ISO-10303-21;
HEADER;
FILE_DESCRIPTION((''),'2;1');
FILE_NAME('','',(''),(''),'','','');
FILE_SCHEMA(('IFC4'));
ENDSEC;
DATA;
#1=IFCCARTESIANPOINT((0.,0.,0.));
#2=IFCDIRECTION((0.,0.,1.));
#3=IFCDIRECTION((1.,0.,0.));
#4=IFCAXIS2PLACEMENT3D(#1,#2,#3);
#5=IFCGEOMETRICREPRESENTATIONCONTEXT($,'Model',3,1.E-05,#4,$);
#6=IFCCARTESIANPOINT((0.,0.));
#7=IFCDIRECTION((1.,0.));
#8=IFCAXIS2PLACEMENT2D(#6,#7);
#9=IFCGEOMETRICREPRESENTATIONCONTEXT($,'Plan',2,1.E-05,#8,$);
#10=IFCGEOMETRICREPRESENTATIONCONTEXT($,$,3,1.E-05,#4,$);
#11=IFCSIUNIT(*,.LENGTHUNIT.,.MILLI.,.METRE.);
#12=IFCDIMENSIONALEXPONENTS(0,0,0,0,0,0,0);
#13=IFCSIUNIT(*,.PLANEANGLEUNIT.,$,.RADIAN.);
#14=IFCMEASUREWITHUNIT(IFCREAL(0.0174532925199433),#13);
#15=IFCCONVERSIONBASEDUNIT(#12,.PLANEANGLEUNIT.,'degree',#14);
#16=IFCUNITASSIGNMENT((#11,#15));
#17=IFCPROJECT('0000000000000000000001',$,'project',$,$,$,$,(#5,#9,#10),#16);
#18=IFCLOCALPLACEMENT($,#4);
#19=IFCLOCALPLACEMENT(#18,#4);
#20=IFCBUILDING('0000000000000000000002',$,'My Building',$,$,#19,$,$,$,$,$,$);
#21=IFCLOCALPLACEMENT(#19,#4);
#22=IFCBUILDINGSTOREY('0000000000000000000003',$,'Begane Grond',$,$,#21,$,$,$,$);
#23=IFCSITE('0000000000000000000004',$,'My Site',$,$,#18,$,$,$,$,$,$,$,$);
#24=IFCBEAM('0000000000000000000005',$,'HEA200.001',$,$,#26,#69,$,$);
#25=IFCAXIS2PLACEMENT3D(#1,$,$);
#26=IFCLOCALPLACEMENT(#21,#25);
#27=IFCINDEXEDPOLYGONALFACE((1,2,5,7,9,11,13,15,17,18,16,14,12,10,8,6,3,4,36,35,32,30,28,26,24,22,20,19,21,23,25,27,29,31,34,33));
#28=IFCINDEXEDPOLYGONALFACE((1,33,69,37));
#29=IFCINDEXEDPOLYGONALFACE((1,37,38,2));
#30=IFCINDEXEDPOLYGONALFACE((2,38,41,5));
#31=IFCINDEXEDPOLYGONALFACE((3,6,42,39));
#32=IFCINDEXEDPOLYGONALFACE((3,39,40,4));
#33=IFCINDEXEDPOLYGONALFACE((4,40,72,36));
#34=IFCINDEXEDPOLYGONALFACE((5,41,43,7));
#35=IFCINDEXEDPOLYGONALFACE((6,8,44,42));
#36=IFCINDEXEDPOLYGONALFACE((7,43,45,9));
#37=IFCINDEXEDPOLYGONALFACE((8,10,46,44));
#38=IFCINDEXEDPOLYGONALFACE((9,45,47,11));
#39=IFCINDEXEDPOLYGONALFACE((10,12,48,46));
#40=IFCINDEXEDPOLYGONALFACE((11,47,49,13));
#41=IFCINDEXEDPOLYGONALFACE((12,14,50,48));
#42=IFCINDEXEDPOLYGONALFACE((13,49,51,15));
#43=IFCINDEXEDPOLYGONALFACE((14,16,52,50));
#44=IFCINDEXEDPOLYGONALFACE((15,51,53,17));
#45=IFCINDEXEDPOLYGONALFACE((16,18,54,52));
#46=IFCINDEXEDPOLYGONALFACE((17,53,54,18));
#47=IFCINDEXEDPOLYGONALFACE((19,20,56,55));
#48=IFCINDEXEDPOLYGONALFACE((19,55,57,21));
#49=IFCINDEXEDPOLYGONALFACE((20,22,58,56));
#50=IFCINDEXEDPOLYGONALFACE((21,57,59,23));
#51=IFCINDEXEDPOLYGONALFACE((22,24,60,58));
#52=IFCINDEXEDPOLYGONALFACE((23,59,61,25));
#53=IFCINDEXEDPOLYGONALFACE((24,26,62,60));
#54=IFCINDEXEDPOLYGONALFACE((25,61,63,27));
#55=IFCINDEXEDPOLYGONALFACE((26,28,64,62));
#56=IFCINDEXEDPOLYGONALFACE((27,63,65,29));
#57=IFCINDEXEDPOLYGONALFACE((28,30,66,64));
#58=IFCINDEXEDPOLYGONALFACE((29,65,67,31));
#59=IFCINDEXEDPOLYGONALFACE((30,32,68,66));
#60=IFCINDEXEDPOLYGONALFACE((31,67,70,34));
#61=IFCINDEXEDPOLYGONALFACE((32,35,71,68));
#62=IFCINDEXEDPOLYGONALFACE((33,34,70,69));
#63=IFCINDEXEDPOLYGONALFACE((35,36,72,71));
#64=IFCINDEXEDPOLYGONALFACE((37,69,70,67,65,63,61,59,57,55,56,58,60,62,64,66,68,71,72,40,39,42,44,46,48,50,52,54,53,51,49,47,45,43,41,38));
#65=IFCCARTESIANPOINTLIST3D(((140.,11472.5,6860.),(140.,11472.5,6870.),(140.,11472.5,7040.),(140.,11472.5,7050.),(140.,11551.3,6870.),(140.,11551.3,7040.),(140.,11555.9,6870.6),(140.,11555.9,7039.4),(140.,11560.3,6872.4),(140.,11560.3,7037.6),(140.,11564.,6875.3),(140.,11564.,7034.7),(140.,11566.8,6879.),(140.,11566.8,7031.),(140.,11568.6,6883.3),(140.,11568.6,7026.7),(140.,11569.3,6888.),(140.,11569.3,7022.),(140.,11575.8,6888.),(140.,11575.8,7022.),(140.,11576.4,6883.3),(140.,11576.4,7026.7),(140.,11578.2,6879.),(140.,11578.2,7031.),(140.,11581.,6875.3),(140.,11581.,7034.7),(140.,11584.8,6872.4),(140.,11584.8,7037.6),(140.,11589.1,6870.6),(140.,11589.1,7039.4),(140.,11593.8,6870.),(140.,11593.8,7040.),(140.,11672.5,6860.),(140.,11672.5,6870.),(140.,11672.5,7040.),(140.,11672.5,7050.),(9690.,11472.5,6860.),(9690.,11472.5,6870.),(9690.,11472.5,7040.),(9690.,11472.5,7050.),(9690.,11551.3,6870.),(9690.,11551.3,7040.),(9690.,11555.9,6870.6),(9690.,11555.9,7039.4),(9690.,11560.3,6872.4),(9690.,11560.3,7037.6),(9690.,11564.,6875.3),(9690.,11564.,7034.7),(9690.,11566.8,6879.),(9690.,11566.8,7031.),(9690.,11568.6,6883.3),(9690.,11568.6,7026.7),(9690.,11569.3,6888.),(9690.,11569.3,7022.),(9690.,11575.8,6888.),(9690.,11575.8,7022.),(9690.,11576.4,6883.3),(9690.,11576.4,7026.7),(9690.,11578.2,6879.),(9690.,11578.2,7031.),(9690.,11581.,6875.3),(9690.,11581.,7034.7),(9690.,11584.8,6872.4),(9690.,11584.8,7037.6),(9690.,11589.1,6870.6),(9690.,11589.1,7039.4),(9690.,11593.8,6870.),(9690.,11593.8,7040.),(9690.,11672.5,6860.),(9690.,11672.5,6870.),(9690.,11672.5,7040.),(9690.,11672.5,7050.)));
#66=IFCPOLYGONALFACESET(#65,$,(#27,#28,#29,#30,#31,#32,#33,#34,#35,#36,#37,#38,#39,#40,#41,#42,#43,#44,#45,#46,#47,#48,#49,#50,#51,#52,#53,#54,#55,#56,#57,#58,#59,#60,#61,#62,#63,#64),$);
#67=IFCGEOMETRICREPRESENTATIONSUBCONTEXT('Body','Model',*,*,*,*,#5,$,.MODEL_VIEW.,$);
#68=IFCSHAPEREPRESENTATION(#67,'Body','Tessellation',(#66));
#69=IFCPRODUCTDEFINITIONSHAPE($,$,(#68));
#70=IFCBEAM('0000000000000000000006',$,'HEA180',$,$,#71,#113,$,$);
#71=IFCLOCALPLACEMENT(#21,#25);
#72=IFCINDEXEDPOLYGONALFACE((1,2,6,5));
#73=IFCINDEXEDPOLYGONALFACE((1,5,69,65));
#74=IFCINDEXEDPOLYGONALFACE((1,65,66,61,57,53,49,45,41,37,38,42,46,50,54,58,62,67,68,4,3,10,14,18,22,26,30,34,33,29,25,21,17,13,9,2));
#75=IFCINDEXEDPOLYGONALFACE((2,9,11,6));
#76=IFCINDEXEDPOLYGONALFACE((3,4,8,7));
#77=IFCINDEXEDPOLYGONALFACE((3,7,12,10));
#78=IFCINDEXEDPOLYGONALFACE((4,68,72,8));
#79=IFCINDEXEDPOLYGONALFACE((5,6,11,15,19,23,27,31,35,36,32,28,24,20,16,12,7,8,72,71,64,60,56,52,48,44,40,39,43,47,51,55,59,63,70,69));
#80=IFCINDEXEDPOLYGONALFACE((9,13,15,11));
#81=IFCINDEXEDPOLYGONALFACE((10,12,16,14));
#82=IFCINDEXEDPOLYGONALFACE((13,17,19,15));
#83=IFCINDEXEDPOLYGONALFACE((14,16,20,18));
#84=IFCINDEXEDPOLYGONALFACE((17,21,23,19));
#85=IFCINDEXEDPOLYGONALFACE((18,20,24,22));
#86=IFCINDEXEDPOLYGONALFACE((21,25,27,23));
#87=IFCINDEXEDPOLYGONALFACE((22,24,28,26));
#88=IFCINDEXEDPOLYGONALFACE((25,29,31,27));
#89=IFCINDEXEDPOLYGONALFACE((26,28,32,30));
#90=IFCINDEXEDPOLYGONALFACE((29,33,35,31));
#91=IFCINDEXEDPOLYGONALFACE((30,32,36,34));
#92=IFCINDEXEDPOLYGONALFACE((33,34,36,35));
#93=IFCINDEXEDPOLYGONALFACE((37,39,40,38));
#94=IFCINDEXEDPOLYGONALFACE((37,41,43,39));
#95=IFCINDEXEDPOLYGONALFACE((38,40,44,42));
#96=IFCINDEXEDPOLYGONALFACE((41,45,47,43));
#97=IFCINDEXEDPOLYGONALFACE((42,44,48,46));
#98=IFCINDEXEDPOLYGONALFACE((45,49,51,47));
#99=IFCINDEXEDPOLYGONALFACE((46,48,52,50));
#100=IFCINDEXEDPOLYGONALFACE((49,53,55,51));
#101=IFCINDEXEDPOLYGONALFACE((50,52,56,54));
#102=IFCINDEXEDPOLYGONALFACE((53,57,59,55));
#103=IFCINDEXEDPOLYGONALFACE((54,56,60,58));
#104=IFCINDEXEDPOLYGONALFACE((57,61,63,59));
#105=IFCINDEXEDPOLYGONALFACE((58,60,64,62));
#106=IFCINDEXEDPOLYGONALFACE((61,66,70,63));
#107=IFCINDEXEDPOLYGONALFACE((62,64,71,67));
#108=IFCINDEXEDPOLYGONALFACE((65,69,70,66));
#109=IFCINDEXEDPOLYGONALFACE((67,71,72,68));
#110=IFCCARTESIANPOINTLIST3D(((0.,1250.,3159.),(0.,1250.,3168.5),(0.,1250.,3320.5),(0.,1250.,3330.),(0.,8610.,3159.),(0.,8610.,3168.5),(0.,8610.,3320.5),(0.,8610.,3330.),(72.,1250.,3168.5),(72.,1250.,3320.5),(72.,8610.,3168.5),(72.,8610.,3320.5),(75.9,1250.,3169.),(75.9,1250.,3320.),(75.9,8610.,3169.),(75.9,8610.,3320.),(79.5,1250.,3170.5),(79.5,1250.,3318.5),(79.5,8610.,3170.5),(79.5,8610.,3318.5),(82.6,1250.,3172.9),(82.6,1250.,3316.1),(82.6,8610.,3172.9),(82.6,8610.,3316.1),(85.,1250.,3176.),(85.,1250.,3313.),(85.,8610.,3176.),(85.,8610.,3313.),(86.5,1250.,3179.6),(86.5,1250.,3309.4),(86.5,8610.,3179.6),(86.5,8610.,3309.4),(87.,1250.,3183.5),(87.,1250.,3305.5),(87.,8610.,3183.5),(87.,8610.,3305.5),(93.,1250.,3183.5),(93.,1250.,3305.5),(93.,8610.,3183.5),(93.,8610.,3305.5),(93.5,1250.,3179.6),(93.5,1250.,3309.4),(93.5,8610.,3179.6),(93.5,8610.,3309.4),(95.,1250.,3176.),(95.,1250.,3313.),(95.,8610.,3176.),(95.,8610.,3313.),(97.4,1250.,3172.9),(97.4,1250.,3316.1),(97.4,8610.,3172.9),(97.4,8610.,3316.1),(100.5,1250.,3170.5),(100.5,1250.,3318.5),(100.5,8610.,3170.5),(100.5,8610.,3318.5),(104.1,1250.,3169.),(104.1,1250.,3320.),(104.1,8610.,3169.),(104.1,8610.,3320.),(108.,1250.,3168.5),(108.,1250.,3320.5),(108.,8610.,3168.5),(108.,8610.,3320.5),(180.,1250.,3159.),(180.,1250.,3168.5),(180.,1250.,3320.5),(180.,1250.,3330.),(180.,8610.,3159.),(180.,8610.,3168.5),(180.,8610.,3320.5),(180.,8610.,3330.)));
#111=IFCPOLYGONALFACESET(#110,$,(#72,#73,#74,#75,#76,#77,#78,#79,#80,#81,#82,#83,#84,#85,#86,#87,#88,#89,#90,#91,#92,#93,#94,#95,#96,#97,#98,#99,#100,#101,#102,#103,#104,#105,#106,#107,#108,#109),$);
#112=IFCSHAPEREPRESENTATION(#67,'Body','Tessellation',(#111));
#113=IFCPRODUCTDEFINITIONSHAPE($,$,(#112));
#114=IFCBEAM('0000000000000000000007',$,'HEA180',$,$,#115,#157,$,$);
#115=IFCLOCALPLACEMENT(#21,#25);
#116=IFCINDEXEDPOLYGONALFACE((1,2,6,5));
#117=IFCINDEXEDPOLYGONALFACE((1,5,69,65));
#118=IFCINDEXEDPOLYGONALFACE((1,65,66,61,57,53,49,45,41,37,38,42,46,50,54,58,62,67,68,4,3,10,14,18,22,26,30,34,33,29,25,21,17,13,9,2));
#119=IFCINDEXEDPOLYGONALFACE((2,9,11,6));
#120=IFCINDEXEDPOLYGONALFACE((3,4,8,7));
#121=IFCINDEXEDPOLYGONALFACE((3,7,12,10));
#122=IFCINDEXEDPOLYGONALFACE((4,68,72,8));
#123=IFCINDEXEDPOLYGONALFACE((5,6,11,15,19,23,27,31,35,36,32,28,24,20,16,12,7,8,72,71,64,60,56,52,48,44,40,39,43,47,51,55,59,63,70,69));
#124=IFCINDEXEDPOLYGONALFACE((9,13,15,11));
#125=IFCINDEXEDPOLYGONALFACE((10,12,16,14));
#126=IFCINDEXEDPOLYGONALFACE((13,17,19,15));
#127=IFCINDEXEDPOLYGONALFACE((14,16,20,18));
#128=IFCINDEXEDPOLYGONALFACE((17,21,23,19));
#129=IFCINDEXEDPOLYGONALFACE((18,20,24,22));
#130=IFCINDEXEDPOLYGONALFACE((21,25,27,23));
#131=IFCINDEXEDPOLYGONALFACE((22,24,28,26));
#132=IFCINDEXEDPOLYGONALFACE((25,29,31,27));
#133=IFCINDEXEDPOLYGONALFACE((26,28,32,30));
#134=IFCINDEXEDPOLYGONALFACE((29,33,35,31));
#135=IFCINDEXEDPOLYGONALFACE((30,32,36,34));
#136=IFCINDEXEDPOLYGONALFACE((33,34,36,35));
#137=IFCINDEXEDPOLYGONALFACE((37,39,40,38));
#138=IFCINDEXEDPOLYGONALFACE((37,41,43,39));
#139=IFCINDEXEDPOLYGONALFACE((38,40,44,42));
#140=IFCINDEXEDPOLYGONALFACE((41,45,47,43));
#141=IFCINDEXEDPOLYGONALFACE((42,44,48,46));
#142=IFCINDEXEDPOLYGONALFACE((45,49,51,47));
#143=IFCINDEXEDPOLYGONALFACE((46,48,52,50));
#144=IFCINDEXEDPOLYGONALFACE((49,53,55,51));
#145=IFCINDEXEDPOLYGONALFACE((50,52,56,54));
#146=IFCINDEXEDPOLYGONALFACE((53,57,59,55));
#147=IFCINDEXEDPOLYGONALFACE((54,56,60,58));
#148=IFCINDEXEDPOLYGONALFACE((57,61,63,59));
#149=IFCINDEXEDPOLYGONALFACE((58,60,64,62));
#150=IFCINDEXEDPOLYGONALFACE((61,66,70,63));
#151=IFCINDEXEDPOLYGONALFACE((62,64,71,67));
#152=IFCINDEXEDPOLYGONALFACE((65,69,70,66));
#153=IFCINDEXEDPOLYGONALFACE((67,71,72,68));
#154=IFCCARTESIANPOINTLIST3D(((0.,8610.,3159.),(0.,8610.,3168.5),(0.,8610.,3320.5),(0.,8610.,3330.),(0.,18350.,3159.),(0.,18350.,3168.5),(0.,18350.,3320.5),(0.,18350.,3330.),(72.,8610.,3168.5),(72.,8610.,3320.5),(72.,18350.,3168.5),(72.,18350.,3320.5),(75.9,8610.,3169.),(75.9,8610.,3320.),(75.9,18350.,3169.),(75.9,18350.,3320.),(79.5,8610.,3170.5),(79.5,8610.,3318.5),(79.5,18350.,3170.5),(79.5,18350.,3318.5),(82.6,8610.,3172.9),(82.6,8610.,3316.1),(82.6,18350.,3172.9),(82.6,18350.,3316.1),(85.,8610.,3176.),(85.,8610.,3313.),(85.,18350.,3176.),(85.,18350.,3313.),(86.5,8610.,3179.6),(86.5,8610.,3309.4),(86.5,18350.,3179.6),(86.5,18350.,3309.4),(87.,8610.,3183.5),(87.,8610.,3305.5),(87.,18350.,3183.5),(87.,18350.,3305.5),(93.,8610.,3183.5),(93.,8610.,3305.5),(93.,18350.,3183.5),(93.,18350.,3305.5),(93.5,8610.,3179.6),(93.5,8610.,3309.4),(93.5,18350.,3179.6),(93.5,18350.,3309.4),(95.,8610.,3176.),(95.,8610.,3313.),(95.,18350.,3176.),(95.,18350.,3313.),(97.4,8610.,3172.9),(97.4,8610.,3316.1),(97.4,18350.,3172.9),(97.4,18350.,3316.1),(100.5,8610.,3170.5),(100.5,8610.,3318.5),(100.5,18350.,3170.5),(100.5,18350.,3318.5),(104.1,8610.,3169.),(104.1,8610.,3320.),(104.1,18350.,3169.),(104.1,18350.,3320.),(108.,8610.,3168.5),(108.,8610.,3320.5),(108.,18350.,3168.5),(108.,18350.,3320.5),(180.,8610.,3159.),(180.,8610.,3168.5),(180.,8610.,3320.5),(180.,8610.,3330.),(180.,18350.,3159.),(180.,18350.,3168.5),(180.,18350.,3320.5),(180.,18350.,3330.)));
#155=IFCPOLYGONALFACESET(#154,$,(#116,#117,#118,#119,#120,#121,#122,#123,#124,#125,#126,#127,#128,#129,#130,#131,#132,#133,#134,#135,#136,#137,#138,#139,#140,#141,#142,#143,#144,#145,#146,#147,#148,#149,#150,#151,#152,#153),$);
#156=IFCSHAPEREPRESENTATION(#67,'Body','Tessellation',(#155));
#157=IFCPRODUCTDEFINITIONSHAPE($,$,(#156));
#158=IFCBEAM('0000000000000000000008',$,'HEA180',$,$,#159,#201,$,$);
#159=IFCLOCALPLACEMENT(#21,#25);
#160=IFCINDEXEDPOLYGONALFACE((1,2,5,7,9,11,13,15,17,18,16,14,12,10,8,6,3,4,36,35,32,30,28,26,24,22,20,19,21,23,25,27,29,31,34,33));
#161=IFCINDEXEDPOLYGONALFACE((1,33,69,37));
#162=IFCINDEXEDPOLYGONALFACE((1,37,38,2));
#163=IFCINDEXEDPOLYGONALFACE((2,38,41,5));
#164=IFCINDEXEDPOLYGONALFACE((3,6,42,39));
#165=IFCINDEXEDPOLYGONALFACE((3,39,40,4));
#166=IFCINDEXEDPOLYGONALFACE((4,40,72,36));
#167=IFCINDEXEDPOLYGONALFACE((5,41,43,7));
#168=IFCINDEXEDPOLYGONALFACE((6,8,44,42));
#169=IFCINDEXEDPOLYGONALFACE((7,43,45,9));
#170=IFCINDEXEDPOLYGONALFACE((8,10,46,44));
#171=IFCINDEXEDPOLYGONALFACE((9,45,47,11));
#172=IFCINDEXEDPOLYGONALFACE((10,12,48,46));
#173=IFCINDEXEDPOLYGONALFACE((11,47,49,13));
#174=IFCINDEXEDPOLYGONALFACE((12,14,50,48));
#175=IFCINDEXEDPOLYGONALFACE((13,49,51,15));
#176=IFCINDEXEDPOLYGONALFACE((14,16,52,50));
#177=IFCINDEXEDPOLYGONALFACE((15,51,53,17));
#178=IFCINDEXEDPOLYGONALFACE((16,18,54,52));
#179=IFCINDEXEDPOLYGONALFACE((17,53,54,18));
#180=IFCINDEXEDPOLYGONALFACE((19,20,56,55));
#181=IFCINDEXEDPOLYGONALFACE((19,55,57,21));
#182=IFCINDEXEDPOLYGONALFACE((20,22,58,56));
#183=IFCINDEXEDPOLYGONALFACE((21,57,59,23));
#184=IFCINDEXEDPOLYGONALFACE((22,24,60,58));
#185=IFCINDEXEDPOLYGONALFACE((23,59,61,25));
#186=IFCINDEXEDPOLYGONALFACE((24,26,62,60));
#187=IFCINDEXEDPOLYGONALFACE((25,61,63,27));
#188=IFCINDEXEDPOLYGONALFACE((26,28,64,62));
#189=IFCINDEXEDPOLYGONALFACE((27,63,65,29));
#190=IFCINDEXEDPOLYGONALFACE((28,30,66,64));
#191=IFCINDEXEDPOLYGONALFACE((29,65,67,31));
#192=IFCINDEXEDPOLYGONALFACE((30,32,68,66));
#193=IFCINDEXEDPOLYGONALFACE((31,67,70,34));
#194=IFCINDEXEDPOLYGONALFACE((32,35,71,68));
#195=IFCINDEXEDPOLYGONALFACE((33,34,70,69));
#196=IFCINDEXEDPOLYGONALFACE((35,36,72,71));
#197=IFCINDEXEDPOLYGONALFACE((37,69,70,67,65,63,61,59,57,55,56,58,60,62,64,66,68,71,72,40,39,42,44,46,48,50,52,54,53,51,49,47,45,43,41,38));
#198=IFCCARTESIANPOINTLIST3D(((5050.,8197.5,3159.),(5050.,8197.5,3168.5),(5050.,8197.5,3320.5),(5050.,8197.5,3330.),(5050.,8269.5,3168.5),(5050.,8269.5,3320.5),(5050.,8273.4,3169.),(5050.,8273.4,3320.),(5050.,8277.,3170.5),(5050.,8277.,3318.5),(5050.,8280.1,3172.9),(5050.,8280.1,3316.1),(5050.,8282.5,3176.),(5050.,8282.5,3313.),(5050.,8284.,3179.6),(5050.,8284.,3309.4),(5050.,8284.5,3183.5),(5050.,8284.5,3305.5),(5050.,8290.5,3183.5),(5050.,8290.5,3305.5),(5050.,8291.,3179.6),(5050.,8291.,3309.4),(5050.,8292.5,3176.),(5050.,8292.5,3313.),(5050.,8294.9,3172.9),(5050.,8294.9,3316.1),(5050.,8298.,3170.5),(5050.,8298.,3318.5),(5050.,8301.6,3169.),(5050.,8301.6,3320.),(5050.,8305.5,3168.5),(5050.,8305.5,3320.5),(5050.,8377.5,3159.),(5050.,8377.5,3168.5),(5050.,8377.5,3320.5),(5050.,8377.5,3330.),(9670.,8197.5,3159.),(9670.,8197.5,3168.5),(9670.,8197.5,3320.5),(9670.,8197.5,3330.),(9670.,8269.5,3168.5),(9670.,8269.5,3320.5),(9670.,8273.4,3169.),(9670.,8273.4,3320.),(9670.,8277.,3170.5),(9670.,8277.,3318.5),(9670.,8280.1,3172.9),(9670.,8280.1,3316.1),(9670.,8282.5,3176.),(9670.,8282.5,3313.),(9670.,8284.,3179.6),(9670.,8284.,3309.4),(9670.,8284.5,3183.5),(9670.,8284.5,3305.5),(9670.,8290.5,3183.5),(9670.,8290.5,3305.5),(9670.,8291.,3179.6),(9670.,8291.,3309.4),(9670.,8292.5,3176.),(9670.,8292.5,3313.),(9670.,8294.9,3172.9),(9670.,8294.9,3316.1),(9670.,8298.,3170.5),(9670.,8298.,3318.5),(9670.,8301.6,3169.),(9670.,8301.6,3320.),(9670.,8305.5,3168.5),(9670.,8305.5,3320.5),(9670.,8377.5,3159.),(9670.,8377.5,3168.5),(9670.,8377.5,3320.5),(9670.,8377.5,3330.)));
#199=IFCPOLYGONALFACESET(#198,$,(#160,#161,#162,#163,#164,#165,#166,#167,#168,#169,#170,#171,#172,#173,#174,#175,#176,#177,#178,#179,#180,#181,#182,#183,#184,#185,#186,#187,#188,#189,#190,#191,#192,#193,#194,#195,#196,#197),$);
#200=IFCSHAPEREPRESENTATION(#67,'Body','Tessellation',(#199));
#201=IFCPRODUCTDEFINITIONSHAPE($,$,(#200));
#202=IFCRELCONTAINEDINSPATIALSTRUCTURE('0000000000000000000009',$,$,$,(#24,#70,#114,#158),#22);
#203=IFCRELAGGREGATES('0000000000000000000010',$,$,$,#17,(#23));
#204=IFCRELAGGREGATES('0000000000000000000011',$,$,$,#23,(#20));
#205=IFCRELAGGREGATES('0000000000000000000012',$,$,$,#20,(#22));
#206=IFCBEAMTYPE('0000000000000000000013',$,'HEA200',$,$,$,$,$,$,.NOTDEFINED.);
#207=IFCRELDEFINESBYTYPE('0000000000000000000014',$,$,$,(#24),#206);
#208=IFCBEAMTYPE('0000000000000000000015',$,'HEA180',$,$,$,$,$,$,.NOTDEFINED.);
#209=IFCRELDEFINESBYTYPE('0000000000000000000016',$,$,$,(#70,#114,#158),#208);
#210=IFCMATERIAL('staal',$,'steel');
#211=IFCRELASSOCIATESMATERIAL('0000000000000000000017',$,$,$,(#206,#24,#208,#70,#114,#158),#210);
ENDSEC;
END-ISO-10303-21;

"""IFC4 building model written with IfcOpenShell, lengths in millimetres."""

from ifc_helpers import new_model, entity, si_unit, converted_unit, frame, origin_with_axes, origin_2d_with_axis, place, context, subcontext, project, spatial, i_section, extrude, material, material_profile, profile_set, profile_usage, type_object, element, save


model = new_model("IFC4")

# Units and contexts
model_context = context("Model", 3, precision=1e-05, world=origin_with_axes())
plan_context = context("Plan", 2, precision=1e-05, world=origin_2d_with_axis())
context_of_model = context(None, 3, precision=1e-05, world=origin_with_axes())
body_context = subcontext(model_context, "Body", "Model", "MODEL_VIEW")
ifc_project = project(units=[si_unit("LENGTHUNIT", "METRE", prefix="MILLI"), converted_unit("PLANEANGLEUNIT", "degree", entity("IfcReal", 0.0174532925199433), si_unit("PLANEANGLEUNIT", "RADIAN"), dimensions=[0, 0, 0, 0, 0, 0, 0])], contexts=[model_context, plan_context, context_of_model])

# Site, building, storey
site_placement = place(None, origin_with_axes())
site = spatial("IfcSite", under=ifc_project, at=site_placement, Name="My Site")
building_placement = place(site_placement, origin_with_axes())
building = spatial("IfcBuilding", under=site, at=building_placement, Name="My Building")
storey_placement = place(building_placement, origin_with_axes())
storey = spatial("IfcBuildingStorey", under=building, at=storey_placement, Name="Begane Grond")

# Shared definitions
ifc_material = material(Name="staal", Category="steel")

# Beams
ifc_material_profile_1 = material_profile(ifc_material, i_section(OverallWidth=200.0, OverallDepth=190.0, WebThickness=6.5, FlangeThickness=10.0, FilletRadius=18.0))
ifc_profile_set_1 = profile_set([ifc_material_profile_1], Name="HEA200")
ifc_profile_usage_1 = profile_usage(ifc_profile_set_1)
beam_type_1 = type_object("IfcBeamType", Name="HEA200", PredefinedType="NOTDEFINED", material=ifc_profile_set_1)
beam_1_placement = place(storey_placement, frame((140.0, 11572.5, 6955.0), z_axis=(1.0, 0.0, 0.0), x_axis=(0.0, 1.0, 0.0)))
element("IfcBeam", 1, at=beam_1_placement, inside=storey, type_object=beam_type_1, material=ifc_profile_usage_1, Name="HEA200.001", context=body_context, shape_type="SweptSolid", body=[
    extrude(i_section(OverallWidth=200.0, OverallDepth=190.0, WebThickness=6.5, FlangeThickness=10.0, FilletRadius=18.0), origin_with_axes(), (0.0, 0.0, 1.0), 9550.0),
])
ifc_material_profile_2 = material_profile(ifc_material, i_section(OverallWidth=180.0, OverallDepth=171.0, WebThickness=6.0, FlangeThickness=9.5, FilletRadius=15.0))
ifc_profile_set_2 = profile_set([ifc_material_profile_2], Name="HEA180")
ifc_profile_usage_2 = profile_usage(ifc_profile_set_2, cardinal=5)
beam_type_2 = type_object("IfcBeamType", Name="HEA180", PredefinedType="NOTDEFINED", material=ifc_profile_set_2)
beam_2_placement = place(storey_placement, frame((90.0, 1250.0, 3244.5), z_axis=(0.0, 1.0, 0.0), x_axis=(-1.0, 0.0, 0.0)))
element("IfcBeam", 2, at=beam_2_placement, inside=storey, type_object=beam_type_2, material=ifc_profile_usage_2, Name="HEA180", context=body_context, shape_type="SweptSolid", body=[
    extrude(i_section(OverallWidth=180.0, OverallDepth=171.0, WebThickness=6.0, FlangeThickness=9.5, FilletRadius=15.0), origin_with_axes(), (0.0, 0.0, 1.0), 7360.0),
])
ifc_profile_usage_3 = profile_usage(ifc_profile_set_2, cardinal=5)
beam_3_placement = place(storey_placement, frame((90.0, 8610.0, 3244.5), z_axis=(0.0, 1.0, 0.0), x_axis=(-1.0, 0.0, 0.0)))
element("IfcBeam", 3, at=beam_3_placement, inside=storey, type_object=beam_type_2, material=ifc_profile_usage_3, Name="HEA180", context=body_context, shape_type="SweptSolid", body=[
    extrude(i_section(OverallWidth=180.0, OverallDepth=171.0, WebThickness=6.0, FlangeThickness=9.5, FilletRadius=15.0), origin_with_axes(), (0.0, 0.0, 1.0), 9740.0),
])
ifc_profile_usage_4 = profile_usage(ifc_profile_set_2)
beam_4_placement = place(storey_placement, frame((5050.0, 8287.5, 3244.5), z_axis=(1.0, 0.0, 0.0), x_axis=(0.0, 1.0, 0.0)))
element("IfcBeam", 4, at=beam_4_placement, inside=storey, type_object=beam_type_2, material=ifc_profile_usage_4, Name="HEA180", context=body_context, shape_type="SweptSolid", body=[
    extrude(i_section(OverallWidth=180.0, OverallDepth=171.0, WebThickness=6.0, FlangeThickness=9.5, FilletRadius=15.0), origin_with_axes(), (0.0, 0.0, 1.0), 4620.0),
])

save(model, "model.ifc")
